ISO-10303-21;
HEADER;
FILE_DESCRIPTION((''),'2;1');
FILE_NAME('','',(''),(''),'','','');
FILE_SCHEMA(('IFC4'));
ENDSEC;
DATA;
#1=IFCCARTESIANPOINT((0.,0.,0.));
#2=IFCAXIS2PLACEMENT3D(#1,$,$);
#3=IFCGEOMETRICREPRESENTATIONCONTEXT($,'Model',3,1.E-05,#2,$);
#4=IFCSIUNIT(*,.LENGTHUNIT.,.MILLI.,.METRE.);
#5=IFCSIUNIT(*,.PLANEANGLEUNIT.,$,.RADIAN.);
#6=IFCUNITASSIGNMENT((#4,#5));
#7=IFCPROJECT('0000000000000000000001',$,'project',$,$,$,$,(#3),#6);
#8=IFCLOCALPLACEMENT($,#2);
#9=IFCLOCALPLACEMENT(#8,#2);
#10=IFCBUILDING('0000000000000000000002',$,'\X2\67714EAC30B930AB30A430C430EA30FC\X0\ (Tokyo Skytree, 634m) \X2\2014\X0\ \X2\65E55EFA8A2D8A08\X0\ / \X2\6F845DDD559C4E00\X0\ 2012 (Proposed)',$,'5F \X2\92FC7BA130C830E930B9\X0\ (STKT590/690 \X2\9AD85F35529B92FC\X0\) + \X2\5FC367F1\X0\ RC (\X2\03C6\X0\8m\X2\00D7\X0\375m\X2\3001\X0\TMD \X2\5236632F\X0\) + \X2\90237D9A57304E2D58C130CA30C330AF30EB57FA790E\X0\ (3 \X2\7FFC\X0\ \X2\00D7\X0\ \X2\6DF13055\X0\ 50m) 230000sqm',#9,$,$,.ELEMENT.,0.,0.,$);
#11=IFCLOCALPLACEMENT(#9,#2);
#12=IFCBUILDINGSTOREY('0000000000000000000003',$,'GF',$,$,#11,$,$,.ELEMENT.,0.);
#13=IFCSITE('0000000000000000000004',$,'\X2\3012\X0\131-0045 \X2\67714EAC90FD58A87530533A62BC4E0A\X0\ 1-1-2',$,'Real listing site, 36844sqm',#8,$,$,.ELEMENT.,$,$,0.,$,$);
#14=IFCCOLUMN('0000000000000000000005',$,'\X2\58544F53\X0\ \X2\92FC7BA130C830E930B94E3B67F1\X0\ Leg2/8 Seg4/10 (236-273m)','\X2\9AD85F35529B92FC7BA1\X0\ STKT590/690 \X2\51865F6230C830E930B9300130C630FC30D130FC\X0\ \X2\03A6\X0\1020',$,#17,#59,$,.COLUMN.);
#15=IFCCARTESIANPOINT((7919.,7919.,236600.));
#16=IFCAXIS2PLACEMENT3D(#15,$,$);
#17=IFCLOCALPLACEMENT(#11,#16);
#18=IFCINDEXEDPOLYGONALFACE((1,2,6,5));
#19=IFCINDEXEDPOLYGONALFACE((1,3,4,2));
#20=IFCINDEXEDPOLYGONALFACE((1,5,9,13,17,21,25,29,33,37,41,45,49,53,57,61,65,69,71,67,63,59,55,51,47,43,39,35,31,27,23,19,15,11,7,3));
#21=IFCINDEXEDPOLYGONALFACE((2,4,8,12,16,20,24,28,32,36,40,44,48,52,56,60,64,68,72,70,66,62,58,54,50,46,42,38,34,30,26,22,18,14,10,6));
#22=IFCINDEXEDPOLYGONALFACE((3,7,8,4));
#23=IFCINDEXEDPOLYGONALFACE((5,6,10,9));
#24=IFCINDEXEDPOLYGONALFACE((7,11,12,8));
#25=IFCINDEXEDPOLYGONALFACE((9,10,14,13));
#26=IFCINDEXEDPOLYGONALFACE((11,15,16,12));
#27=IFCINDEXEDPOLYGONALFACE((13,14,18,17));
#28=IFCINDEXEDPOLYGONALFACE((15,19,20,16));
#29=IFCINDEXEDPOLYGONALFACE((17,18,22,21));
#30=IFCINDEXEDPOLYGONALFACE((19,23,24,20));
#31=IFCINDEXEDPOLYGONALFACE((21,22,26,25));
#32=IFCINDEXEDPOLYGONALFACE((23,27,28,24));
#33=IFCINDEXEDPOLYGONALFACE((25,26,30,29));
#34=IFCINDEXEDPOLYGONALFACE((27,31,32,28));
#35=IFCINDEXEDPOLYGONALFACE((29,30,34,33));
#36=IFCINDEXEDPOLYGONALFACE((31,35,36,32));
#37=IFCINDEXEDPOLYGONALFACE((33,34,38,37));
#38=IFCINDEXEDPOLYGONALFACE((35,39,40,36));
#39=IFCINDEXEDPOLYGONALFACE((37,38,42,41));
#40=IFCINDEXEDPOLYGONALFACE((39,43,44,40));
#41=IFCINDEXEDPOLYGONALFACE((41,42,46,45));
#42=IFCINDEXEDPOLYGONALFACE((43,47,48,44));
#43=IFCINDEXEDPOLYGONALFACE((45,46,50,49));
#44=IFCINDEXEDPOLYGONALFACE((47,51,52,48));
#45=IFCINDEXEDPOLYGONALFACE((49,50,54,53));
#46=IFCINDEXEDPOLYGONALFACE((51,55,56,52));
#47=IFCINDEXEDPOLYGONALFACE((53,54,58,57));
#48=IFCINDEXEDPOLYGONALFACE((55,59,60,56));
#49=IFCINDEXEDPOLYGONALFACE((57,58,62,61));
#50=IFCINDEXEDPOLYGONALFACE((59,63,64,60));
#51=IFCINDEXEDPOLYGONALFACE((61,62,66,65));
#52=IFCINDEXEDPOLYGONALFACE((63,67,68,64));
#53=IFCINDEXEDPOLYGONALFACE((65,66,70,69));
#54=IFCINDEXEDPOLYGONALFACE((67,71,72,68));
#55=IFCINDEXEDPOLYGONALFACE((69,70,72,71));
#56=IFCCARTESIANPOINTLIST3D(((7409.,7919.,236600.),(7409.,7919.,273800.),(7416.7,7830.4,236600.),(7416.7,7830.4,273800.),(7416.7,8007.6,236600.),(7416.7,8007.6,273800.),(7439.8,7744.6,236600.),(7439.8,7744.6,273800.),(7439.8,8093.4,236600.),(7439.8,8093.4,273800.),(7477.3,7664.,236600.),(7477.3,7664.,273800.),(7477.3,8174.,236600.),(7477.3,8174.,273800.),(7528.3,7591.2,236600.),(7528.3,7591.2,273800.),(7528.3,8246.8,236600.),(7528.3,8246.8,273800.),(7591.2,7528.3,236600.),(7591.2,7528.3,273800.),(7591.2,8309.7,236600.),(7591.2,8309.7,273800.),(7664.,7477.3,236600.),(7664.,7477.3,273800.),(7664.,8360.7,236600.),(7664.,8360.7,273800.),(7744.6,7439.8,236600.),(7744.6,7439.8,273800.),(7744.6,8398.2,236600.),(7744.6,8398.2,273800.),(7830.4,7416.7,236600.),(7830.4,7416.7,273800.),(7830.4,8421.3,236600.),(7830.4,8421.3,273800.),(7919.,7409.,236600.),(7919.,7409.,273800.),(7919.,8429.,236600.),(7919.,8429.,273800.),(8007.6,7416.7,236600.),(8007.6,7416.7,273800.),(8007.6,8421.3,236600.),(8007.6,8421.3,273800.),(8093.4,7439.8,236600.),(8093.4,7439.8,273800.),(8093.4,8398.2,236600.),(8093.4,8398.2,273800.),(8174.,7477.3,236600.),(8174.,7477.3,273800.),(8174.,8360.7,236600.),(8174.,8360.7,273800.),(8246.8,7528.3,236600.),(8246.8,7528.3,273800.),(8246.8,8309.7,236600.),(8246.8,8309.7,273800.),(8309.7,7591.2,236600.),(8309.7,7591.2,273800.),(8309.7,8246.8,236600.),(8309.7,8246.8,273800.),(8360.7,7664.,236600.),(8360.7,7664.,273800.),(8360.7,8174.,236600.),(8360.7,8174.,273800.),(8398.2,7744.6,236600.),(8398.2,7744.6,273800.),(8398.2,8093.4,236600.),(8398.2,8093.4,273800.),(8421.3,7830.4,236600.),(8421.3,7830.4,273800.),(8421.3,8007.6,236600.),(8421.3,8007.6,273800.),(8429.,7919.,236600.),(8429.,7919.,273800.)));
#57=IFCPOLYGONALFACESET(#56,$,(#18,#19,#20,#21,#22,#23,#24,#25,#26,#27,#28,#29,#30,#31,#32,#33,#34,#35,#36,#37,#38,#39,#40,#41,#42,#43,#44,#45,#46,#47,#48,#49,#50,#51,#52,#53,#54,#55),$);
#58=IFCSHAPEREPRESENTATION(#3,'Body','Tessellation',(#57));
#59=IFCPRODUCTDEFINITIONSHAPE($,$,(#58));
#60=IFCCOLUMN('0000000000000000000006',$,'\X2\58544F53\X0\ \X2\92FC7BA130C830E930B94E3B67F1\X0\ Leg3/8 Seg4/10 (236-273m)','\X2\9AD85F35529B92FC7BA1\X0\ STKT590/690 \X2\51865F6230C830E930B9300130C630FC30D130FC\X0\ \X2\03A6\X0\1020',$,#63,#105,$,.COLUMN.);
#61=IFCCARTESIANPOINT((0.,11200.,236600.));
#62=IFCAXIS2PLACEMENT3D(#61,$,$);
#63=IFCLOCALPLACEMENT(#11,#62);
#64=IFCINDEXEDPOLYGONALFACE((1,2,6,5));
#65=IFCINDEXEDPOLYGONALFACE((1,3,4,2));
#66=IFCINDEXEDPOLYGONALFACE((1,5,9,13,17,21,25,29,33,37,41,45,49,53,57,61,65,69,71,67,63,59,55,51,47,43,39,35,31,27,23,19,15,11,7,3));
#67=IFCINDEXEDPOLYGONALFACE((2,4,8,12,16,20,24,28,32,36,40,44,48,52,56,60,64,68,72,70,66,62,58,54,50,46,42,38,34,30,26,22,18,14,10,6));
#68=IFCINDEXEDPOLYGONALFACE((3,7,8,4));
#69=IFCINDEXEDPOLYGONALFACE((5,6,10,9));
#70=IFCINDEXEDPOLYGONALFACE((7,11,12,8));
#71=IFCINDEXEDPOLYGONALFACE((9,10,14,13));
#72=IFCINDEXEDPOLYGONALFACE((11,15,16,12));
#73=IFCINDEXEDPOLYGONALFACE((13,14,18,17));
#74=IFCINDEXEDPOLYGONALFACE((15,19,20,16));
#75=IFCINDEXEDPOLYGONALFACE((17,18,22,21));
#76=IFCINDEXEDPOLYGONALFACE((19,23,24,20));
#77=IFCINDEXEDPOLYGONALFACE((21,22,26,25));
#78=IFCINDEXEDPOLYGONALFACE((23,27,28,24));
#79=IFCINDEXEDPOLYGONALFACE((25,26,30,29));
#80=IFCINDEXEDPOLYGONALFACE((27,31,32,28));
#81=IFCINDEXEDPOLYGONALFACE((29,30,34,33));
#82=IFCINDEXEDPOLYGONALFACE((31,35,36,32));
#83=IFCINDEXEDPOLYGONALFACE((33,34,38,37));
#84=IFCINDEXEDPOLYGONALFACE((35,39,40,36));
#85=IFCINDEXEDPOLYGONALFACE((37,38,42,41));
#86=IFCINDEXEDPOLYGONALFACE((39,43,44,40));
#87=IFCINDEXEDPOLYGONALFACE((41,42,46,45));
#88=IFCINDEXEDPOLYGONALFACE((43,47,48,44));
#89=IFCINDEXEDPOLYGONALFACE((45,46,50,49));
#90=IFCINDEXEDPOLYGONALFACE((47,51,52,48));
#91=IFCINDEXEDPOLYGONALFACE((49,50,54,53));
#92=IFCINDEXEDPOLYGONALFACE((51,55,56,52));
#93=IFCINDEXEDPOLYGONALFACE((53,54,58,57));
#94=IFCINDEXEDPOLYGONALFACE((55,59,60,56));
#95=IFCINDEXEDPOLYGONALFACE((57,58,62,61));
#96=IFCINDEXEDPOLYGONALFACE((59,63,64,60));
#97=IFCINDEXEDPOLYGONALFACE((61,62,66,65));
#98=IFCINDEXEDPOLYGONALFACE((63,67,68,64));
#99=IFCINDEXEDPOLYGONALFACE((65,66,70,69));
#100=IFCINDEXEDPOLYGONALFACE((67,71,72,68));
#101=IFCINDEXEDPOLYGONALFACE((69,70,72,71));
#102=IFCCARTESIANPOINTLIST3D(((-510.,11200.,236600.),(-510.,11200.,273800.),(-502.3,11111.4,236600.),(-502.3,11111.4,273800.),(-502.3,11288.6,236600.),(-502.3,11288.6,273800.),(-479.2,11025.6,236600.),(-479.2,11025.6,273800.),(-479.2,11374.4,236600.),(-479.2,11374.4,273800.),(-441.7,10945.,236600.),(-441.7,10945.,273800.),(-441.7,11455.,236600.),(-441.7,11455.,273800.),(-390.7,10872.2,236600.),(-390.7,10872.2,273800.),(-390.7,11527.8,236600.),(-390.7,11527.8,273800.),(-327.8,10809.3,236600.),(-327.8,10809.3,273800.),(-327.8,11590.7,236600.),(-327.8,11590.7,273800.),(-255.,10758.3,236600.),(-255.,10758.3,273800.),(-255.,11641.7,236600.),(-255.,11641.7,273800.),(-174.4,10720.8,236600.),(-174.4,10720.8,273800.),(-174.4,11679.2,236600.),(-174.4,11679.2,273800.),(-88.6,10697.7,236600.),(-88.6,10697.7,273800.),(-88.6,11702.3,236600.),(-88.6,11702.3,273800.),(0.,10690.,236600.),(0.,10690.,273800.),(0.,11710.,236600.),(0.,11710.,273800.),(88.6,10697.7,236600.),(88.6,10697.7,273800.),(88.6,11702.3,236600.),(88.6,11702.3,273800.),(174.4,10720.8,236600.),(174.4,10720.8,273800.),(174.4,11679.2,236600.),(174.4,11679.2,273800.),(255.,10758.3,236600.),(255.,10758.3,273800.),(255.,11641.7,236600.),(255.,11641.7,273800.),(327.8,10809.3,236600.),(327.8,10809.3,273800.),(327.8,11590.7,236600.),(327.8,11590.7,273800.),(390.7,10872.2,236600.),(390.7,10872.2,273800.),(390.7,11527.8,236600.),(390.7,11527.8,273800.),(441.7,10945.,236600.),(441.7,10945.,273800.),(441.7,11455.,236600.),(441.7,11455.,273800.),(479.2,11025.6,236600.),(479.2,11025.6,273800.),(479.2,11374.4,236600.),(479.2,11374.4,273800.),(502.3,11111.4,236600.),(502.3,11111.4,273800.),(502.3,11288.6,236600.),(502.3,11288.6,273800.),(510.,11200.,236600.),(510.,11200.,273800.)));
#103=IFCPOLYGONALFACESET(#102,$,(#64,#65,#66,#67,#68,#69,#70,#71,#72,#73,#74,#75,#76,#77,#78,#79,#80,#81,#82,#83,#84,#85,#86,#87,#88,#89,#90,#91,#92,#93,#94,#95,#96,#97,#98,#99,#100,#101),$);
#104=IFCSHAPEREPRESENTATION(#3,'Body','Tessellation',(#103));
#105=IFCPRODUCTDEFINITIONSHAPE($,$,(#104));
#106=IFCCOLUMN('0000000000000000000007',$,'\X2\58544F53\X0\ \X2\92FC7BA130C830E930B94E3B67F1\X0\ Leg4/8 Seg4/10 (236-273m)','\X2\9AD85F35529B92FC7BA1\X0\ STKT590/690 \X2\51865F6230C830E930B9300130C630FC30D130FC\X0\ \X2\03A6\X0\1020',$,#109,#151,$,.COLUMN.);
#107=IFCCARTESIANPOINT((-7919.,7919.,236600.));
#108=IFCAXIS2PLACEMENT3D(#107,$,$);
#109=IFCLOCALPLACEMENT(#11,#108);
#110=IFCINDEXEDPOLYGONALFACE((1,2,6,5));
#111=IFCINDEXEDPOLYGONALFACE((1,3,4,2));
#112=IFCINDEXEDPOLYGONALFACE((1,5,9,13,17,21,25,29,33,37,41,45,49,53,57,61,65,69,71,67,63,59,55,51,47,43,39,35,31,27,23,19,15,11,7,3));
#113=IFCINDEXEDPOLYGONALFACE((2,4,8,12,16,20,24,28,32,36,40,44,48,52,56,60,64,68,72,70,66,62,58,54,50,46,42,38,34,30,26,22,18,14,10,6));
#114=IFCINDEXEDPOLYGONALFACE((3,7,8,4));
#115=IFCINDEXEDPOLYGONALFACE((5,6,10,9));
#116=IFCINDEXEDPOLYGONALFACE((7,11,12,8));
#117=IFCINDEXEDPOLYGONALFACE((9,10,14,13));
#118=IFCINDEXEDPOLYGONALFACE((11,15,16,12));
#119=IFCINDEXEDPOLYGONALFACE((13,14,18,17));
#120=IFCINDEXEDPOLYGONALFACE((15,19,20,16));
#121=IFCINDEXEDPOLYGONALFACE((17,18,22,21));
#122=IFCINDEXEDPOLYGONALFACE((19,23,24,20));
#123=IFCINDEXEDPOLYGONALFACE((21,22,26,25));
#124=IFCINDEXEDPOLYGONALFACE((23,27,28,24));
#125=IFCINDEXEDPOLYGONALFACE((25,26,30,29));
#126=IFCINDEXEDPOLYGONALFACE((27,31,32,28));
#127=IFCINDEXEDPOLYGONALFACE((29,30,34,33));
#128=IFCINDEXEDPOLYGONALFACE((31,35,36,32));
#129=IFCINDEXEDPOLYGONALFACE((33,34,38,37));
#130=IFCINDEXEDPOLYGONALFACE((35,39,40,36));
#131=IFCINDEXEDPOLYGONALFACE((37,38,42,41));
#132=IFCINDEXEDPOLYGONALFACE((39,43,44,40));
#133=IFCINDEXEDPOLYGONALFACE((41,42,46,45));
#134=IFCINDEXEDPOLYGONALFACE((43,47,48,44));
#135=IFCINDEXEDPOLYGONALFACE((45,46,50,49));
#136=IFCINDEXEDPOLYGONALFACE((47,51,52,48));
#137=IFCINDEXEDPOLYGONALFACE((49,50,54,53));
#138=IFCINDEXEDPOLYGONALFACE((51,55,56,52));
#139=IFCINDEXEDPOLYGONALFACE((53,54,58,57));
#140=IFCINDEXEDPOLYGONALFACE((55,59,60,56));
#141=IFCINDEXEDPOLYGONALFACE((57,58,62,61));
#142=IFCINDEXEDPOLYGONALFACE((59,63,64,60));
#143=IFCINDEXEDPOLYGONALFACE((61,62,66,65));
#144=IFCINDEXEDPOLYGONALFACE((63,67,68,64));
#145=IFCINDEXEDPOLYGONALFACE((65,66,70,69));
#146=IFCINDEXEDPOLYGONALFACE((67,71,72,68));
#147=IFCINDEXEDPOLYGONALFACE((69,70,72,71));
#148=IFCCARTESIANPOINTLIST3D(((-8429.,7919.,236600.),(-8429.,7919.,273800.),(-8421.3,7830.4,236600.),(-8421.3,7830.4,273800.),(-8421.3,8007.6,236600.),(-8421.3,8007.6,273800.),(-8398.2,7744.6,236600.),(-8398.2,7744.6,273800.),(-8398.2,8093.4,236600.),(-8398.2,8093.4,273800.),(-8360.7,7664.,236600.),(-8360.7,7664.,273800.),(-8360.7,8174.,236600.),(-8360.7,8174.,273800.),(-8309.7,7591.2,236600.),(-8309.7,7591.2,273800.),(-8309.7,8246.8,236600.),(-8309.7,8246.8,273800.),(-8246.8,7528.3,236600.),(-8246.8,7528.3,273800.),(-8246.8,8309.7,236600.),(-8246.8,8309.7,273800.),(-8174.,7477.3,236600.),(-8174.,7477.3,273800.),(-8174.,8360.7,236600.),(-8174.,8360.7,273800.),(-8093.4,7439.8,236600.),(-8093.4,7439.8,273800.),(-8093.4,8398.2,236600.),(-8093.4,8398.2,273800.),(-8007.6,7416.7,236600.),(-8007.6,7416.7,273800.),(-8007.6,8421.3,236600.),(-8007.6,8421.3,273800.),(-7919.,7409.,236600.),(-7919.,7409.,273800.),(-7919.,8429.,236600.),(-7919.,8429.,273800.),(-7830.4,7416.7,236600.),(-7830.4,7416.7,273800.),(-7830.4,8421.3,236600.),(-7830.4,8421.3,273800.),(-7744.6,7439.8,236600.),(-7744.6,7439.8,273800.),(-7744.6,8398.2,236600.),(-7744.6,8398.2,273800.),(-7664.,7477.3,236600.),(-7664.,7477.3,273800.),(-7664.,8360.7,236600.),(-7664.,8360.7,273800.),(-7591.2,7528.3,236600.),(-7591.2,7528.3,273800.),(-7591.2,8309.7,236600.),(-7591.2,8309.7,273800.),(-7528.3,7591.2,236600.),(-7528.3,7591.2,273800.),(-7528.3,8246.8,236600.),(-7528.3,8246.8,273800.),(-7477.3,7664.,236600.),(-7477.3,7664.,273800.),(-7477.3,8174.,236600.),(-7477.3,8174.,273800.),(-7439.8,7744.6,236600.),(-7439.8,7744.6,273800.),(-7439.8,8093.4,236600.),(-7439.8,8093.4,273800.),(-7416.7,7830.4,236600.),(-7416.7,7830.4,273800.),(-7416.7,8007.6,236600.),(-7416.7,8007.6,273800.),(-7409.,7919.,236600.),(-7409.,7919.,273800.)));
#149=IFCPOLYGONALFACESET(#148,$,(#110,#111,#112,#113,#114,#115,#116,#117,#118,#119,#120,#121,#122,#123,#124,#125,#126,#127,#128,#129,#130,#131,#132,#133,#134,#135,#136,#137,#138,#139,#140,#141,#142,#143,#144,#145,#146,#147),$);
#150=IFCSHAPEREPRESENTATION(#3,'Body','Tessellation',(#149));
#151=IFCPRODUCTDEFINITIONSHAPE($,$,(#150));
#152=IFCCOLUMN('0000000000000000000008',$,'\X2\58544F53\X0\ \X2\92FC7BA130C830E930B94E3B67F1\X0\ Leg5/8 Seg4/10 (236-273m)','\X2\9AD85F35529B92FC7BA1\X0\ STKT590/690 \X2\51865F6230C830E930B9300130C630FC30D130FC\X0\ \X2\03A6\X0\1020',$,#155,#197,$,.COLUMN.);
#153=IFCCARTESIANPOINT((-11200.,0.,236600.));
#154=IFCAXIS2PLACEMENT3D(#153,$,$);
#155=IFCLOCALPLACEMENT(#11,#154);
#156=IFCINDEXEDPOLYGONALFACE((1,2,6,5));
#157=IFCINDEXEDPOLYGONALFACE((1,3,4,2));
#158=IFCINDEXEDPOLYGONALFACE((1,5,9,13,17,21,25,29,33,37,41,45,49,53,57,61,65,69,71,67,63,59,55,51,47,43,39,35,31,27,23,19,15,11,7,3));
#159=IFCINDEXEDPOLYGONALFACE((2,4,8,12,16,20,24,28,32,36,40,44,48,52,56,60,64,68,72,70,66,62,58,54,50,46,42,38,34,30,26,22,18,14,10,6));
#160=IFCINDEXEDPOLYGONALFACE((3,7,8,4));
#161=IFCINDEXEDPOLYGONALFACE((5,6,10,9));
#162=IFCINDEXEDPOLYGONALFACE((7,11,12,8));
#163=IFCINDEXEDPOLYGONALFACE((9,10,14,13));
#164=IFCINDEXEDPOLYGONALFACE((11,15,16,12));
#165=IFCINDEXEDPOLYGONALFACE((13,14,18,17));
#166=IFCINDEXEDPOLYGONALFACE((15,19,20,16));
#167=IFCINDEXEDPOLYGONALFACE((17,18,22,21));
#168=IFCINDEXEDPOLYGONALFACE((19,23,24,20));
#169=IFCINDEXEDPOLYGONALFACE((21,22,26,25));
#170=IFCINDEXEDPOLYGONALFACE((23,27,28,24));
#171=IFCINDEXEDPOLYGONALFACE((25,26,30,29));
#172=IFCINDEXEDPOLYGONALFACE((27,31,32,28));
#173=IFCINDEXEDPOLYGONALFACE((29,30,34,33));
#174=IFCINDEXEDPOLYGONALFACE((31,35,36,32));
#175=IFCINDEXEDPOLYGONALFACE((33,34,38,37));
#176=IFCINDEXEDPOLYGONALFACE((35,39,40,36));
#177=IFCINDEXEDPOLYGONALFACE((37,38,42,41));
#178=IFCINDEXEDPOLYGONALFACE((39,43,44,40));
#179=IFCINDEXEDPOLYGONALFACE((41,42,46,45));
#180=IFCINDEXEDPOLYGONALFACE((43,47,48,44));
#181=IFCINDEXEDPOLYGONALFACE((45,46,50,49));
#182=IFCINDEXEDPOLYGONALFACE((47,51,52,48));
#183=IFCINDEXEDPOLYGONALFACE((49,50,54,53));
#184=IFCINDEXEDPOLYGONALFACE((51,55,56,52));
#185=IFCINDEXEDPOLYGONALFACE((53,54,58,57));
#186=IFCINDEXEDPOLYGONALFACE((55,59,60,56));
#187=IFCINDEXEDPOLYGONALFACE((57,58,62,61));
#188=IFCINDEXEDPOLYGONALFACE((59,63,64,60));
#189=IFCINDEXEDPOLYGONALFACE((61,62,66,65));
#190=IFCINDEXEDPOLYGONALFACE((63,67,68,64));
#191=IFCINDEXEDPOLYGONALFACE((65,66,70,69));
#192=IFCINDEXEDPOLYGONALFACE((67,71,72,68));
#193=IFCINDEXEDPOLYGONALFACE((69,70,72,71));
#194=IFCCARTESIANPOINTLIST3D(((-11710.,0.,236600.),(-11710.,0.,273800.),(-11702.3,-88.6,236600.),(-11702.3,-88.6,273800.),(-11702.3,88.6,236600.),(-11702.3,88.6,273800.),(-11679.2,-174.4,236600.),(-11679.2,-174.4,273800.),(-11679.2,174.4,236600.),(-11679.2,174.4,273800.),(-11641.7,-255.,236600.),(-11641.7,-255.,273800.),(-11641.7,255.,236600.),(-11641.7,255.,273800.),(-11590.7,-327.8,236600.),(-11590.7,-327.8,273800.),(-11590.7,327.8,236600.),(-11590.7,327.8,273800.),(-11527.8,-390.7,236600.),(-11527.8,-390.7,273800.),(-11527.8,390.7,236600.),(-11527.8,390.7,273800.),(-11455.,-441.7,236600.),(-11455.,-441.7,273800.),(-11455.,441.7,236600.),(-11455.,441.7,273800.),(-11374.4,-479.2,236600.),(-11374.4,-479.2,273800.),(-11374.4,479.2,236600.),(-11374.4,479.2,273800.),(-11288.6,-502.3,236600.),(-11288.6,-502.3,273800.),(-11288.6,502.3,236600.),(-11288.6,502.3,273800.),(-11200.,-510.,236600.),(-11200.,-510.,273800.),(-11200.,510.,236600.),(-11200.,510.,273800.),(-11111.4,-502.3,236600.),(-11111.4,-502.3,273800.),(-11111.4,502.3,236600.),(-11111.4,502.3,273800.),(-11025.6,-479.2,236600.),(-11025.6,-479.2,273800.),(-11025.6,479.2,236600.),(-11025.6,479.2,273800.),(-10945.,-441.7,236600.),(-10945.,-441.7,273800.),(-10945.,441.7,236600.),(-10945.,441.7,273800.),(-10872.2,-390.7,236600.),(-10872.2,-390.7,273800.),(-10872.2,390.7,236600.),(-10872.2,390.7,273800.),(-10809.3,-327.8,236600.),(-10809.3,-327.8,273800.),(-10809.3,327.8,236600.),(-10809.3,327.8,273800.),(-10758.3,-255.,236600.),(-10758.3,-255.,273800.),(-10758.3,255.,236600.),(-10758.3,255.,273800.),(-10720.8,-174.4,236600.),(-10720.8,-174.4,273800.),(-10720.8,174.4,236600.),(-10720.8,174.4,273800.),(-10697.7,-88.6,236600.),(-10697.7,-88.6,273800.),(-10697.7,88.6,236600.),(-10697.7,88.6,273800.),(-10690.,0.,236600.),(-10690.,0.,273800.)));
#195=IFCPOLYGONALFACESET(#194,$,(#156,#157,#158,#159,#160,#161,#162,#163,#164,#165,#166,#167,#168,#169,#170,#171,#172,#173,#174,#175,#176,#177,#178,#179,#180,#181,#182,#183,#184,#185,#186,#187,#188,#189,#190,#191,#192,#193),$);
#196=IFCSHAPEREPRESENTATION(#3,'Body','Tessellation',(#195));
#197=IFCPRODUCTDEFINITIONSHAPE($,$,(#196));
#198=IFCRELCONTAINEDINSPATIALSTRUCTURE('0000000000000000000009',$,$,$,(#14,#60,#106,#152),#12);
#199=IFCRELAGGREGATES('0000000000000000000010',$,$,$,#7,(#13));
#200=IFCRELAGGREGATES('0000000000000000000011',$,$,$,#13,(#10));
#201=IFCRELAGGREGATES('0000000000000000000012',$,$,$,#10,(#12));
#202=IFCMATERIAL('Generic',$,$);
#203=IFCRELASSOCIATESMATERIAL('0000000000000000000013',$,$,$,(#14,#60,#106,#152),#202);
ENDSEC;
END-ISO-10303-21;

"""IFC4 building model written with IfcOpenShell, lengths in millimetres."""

from ifc_helpers import new_model, si_unit, frame, origin, origin_2d, place, context, project, spatial, circle, extrude, material, element, save


model = new_model("IFC4")

# Units and contexts
model_context = context("Model", 3, precision=1e-05, world=origin())
ifc_project = project(units=[si_unit("LENGTHUNIT", "METRE", prefix="MILLI"), si_unit("PLANEANGLEUNIT", "RADIAN")], contexts=[model_context])

# Site, building, storey
site_placement = place(None, origin())
site = spatial("IfcSite", under=ifc_project, at=site_placement, Name="〒131-0045 東京都墨田区押上 1-1-2", ObjectType="Real listing site, 36844sqm", CompositionType="ELEMENT", RefElevation=0.0)
building_placement = place(site_placement, origin())
building = spatial("IfcBuilding", under=site, at=building_placement, Name="東京スカイツリー (Tokyo Skytree, 634m) — 日建設計 / 澄川喜一 2012 (Proposed)", ObjectType="5F 鋼管トラス (STKT590/690 高張力鋼) + 心柱 RC (φ8m×375m、TMD 制振) + 連続地中壁ナックル基礎 (3 翼 × 深さ 50m) 230000sqm", CompositionType="ELEMENT", ElevationOfRefHeight=0.0, ElevationOfTerrain=0.0)
storey_placement = place(building_placement, origin())
storey = spatial("IfcBuildingStorey", under=building, at=storey_placement, Name="GF", CompositionType="ELEMENT", Elevation=0.0)

# Columns
ifc_material_1 = material(Name="Generic")
column_1_placement = place(storey_placement, frame((7919.0, 7919.0, 236600.0)))
element("IfcColumn", 1, at=column_1_placement, inside=storey, material=ifc_material_1, Name="塔体 鋼管トラス主柱 Leg2/8 Seg4/10 (236-273m)", Description="高張力鋼管 STKT590/690 円形トラス、テーパー Φ1020", PredefinedType="COLUMN", context=model_context, shape_type="SweptSolid", body=[
    extrude(circle(Radius=510.0, at=origin_2d()), frame((7919.0, 7919.0, 236600.0)), (0.0, 0.0, 1.0), 37200.0),
])
column_2_placement = place(storey_placement, frame((0.0, 11200.0, 236600.0)))
element("IfcColumn", 2, at=column_2_placement, inside=storey, material=ifc_material_1, Name="塔体 鋼管トラス主柱 Leg3/8 Seg4/10 (236-273m)", Description="高張力鋼管 STKT590/690 円形トラス、テーパー Φ1020", PredefinedType="COLUMN", context=model_context, shape_type="SweptSolid", body=[
    extrude(circle(Radius=510.0, at=origin_2d()), frame((0.0, 11200.0, 236600.0)), (0.0, 0.0, 1.0), 37200.0),
])
column_3_placement = place(storey_placement, frame((-7919.0, 7919.0, 236600.0)))
element("IfcColumn", 3, at=column_3_placement, inside=storey, material=ifc_material_1, Name="塔体 鋼管トラス主柱 Leg4/8 Seg4/10 (236-273m)", Description="高張力鋼管 STKT590/690 円形トラス、テーパー Φ1020", PredefinedType="COLUMN", context=model_context, shape_type="SweptSolid", body=[
    extrude(circle(Radius=510.0, at=origin_2d()), frame((-7919.0, 7919.0, 236600.0)), (0.0, 0.0, 1.0), 37200.0),
])
column_4_placement = place(storey_placement, frame((-11200.0, 0.0, 236600.0)))
element("IfcColumn", 4, at=column_4_placement, inside=storey, material=ifc_material_1, Name="塔体 鋼管トラス主柱 Leg5/8 Seg4/10 (236-273m)", Description="高張力鋼管 STKT590/690 円形トラス、テーパー Φ1020", PredefinedType="COLUMN", context=model_context, shape_type="SweptSolid", body=[
    extrude(circle(Radius=510.0, at=origin_2d()), frame((-11200.0, 0.0, 236600.0)), (0.0, 0.0, 1.0), 37200.0),
])

save(model, "model.ifc")
